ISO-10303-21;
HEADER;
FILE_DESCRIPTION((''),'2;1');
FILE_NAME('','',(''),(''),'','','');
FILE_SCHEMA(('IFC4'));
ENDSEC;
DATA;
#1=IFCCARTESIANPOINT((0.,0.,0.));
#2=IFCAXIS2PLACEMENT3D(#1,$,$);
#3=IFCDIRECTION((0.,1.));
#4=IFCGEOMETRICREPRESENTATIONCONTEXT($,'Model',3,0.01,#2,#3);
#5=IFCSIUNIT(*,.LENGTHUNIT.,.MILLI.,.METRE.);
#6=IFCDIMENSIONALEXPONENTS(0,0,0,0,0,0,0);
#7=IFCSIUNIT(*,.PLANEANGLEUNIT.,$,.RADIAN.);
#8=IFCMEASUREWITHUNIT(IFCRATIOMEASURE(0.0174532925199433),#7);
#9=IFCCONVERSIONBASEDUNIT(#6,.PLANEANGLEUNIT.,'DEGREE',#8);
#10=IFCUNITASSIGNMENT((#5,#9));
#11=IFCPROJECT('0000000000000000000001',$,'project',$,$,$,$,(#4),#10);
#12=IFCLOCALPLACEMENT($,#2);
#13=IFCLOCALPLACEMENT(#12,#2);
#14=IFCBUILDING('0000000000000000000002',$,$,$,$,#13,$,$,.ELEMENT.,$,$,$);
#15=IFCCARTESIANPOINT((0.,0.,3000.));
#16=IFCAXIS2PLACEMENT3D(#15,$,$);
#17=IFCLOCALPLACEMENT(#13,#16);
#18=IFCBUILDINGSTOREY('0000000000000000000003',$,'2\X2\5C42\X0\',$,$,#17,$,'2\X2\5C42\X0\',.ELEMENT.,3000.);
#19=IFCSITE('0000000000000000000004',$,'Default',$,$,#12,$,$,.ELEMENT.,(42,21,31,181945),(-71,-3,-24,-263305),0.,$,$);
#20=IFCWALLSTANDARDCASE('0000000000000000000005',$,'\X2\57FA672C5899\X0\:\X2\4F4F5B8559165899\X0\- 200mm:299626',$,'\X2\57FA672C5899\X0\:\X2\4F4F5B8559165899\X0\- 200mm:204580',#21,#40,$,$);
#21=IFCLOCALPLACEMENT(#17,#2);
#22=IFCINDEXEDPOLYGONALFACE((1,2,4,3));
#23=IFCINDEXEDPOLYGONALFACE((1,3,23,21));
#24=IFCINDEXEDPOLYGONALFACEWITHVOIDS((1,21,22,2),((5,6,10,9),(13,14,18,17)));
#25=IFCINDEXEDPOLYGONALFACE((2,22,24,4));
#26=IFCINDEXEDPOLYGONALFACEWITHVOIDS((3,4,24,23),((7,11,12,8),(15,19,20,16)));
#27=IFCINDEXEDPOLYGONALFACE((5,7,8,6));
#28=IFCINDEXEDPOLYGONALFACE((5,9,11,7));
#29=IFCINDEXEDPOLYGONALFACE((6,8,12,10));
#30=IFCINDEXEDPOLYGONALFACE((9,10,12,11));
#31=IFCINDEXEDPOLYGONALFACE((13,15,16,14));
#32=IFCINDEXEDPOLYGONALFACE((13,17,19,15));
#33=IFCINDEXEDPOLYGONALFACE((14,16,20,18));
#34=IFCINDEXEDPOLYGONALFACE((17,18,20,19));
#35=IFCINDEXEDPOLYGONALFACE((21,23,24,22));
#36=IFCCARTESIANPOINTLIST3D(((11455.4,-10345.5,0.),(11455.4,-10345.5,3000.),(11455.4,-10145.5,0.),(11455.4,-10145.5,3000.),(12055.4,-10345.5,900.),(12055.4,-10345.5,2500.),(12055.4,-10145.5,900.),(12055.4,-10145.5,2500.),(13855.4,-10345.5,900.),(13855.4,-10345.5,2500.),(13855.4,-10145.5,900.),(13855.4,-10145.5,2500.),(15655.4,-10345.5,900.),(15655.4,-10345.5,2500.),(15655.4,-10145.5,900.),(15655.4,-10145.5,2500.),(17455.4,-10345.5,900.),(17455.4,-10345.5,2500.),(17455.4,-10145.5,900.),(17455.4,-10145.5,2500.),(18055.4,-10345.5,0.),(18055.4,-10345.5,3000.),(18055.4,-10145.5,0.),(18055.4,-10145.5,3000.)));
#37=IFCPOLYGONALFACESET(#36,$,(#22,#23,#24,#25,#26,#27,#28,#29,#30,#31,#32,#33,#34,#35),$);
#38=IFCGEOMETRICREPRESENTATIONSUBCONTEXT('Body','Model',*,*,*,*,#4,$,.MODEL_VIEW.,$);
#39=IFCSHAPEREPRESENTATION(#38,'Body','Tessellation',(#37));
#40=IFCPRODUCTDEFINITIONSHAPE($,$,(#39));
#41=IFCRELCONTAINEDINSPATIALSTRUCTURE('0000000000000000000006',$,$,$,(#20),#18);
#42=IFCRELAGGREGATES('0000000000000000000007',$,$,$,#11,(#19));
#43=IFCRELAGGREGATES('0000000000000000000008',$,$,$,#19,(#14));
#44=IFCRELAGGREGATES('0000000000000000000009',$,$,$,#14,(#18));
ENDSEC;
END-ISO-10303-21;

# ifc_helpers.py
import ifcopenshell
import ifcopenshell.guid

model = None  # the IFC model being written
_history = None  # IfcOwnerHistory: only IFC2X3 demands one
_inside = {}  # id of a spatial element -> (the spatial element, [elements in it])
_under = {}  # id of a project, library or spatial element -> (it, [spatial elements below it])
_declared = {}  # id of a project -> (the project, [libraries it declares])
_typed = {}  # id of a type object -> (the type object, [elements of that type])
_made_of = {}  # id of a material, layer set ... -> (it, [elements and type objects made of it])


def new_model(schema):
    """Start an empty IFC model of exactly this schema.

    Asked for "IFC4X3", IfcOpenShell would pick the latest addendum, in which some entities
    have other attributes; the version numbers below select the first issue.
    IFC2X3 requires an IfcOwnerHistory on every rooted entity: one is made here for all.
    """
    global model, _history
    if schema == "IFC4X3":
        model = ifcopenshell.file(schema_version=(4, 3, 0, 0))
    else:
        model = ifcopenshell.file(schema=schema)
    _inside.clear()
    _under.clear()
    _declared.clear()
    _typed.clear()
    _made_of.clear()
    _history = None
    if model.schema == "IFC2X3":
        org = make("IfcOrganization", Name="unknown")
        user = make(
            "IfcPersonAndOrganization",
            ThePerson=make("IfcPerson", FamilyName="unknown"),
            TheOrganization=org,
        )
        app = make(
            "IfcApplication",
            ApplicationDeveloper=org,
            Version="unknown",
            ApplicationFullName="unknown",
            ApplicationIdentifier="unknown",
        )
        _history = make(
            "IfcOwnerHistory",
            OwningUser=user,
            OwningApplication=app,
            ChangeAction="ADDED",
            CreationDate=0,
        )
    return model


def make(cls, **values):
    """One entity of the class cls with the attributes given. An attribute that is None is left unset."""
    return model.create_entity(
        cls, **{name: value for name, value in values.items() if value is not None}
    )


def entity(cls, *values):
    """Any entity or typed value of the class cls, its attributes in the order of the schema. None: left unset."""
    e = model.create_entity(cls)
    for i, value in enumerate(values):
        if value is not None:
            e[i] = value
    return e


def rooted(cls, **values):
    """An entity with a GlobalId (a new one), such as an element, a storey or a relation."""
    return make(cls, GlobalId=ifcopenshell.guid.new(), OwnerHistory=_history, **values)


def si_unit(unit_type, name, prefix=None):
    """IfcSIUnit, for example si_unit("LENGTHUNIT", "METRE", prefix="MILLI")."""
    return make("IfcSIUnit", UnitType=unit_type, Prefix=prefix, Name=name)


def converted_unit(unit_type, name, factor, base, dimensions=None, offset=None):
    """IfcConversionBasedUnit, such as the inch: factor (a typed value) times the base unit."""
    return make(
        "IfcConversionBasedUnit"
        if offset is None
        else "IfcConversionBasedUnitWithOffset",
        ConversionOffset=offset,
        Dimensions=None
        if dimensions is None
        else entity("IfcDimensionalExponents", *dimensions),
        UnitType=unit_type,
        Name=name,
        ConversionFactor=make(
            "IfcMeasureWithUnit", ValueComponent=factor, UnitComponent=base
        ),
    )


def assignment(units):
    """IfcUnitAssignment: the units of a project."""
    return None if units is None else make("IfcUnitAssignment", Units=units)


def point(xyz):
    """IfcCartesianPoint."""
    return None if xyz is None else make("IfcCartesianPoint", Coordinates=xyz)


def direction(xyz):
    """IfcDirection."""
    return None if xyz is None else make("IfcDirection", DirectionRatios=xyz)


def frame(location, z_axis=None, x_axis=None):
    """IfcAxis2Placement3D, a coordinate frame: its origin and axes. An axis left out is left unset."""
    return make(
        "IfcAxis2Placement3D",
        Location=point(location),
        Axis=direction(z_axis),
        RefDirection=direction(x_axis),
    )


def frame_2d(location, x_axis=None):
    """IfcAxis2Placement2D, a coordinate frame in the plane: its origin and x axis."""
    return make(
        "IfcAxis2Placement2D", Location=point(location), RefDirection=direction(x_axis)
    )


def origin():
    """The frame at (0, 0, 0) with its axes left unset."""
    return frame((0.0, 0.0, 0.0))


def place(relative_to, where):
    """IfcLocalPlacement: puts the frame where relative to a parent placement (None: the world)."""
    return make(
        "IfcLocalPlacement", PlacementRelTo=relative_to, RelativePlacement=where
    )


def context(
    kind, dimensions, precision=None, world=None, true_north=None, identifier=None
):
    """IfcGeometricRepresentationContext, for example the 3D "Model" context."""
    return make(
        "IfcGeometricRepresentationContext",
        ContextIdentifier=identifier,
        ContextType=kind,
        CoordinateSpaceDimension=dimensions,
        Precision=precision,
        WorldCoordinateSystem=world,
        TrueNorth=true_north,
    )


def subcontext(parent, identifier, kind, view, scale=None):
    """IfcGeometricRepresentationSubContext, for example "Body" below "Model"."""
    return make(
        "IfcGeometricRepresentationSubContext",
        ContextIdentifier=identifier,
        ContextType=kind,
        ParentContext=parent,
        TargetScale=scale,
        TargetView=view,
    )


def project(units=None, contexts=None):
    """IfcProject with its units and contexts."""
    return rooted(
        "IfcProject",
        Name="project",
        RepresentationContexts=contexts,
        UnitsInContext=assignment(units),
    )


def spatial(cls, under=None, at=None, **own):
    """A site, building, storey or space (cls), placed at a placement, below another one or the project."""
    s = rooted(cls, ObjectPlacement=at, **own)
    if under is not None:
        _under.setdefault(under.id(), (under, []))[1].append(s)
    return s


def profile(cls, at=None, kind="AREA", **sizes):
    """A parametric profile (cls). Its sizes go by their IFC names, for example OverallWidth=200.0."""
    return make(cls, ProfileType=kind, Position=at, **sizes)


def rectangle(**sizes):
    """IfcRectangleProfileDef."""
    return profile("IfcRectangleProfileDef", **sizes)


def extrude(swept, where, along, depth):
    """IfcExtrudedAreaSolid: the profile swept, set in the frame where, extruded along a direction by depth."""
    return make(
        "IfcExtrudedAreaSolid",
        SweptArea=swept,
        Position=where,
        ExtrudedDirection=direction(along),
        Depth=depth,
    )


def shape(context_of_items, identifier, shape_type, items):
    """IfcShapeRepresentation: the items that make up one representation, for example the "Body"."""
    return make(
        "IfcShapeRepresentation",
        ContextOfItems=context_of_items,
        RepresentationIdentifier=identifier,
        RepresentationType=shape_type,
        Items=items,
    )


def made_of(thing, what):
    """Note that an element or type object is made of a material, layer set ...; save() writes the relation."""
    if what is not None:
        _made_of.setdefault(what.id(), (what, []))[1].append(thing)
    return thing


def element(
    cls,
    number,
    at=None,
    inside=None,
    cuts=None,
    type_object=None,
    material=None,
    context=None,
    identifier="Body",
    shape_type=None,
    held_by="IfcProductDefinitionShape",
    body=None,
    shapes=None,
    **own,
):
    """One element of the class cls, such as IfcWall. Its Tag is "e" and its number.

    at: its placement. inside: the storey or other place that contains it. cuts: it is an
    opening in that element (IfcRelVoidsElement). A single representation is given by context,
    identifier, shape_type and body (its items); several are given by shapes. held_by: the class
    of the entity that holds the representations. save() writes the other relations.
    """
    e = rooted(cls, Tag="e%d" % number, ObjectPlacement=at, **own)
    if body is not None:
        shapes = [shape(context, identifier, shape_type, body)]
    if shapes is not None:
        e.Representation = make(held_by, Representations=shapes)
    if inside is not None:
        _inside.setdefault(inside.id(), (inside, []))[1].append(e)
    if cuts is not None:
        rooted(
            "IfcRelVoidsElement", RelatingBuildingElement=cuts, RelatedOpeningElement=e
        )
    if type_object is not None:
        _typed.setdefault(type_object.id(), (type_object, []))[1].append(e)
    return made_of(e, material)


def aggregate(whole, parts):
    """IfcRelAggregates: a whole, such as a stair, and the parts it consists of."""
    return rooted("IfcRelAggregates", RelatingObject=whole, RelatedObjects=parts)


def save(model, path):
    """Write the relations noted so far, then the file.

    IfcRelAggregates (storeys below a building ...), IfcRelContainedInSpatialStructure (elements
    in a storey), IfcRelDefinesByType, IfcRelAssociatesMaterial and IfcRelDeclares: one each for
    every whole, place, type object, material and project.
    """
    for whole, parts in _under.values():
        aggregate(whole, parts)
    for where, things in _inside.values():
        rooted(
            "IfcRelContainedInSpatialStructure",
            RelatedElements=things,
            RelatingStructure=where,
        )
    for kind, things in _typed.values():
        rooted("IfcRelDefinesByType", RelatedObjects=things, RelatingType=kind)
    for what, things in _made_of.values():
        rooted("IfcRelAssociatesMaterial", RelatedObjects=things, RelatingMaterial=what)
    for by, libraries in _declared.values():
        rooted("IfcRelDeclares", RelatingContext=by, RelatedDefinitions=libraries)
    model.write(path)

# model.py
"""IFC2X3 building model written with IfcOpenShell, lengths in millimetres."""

from ifc_helpers import new_model, entity, si_unit, converted_unit, direction, frame, frame_2d, origin, place, context, subcontext, project, spatial, rectangle, extrude, element, save


model = new_model("IFC2X3")

# Units and contexts
model_context = context("Model", 3, precision=0.01, world=origin(), true_north=direction((0.0, 1.0)))
body_context = subcontext(model_context, "Body", "Model", "MODEL_VIEW")
ifc_project = project(units=[si_unit("LENGTHUNIT", "METRE", prefix="MILLI"), converted_unit("PLANEANGLEUNIT", "DEGREE", entity("IfcRatioMeasure", 0.0174532925199433), si_unit("PLANEANGLEUNIT", "RADIAN"), dimensions=[0, 0, 0, 0, 0, 0, 0])], contexts=[model_context])

# Site, building, storey
site_placement = place(None, origin())
site = spatial("IfcSite", under=ifc_project, at=site_placement, Name="Default", CompositionType="ELEMENT", RefLatitude=(42, 21, 31, 181945), RefLongitude=(-71, -3, -24, -263305), RefElevation=0.0)
building_placement = place(site_placement, origin())
building = spatial("IfcBuilding", under=site, at=building_placement, CompositionType="ELEMENT")
storey_placement = place(building_placement, frame((0.0, 0.0, 3000.0)))
storey = spatial("IfcBuildingStorey", under=building, at=storey_placement, Name="2层", LongName="2层", CompositionType="ELEMENT", Elevation=3000.0)

# Wall, openings
wall_placement = place(storey_placement, frame((11455.4, -10245.5, 0.0)))
wall = element("IfcWallStandardCase", 1, at=wall_placement, inside=storey, Name="基本墙:住宅外墙- 200mm:299626", ObjectType="基本墙:住宅外墙- 200mm:204580", context=body_context, shape_type="SweptSolid", body=[
    extrude(rectangle(XDim=6600.0, YDim=200.0, at=frame_2d((3300.0, 0.0), x_axis=(-1.0, 0.0))), origin(), (0.0, 0.0, 1.0), 3000.0),
])
opening_1_placement = place(wall_placement, frame((600.0, -100.0, 900.0)))
element("IfcOpeningElement", 2, at=opening_1_placement, cuts=wall, ObjectType="Opening", context=body_context, shape_type="SweptSolid", body=[
    extrude(rectangle(XDim=1600.0, YDim=1800.0, at=frame_2d((800.0, 900.0), x_axis=(1.0, 0.0))), frame((0.0, 0.0, 0.0), z_axis=(0.0, 1.0, 0.0), x_axis=(0.0, 0.0, 1.0)), (0.0, 0.0, 1.0), 200.0),
])
opening_2_placement = place(wall_placement, frame((4200.0, -100.0, 900.0)))
element("IfcOpeningElement", 3, at=opening_2_placement, cuts=wall, ObjectType="Opening", context=body_context, shape_type="SweptSolid", body=[
    extrude(rectangle(XDim=1600.0, YDim=1800.0, at=frame_2d((800.0, 900.0), x_axis=(1.0, 0.0))), frame((0.0, 0.0, 0.0), z_axis=(0.0, 1.0, 0.0), x_axis=(0.0, 0.0, 1.0)), (0.0, 0.0, 1.0), 200.0),
])

save(model, "model.ifc")
